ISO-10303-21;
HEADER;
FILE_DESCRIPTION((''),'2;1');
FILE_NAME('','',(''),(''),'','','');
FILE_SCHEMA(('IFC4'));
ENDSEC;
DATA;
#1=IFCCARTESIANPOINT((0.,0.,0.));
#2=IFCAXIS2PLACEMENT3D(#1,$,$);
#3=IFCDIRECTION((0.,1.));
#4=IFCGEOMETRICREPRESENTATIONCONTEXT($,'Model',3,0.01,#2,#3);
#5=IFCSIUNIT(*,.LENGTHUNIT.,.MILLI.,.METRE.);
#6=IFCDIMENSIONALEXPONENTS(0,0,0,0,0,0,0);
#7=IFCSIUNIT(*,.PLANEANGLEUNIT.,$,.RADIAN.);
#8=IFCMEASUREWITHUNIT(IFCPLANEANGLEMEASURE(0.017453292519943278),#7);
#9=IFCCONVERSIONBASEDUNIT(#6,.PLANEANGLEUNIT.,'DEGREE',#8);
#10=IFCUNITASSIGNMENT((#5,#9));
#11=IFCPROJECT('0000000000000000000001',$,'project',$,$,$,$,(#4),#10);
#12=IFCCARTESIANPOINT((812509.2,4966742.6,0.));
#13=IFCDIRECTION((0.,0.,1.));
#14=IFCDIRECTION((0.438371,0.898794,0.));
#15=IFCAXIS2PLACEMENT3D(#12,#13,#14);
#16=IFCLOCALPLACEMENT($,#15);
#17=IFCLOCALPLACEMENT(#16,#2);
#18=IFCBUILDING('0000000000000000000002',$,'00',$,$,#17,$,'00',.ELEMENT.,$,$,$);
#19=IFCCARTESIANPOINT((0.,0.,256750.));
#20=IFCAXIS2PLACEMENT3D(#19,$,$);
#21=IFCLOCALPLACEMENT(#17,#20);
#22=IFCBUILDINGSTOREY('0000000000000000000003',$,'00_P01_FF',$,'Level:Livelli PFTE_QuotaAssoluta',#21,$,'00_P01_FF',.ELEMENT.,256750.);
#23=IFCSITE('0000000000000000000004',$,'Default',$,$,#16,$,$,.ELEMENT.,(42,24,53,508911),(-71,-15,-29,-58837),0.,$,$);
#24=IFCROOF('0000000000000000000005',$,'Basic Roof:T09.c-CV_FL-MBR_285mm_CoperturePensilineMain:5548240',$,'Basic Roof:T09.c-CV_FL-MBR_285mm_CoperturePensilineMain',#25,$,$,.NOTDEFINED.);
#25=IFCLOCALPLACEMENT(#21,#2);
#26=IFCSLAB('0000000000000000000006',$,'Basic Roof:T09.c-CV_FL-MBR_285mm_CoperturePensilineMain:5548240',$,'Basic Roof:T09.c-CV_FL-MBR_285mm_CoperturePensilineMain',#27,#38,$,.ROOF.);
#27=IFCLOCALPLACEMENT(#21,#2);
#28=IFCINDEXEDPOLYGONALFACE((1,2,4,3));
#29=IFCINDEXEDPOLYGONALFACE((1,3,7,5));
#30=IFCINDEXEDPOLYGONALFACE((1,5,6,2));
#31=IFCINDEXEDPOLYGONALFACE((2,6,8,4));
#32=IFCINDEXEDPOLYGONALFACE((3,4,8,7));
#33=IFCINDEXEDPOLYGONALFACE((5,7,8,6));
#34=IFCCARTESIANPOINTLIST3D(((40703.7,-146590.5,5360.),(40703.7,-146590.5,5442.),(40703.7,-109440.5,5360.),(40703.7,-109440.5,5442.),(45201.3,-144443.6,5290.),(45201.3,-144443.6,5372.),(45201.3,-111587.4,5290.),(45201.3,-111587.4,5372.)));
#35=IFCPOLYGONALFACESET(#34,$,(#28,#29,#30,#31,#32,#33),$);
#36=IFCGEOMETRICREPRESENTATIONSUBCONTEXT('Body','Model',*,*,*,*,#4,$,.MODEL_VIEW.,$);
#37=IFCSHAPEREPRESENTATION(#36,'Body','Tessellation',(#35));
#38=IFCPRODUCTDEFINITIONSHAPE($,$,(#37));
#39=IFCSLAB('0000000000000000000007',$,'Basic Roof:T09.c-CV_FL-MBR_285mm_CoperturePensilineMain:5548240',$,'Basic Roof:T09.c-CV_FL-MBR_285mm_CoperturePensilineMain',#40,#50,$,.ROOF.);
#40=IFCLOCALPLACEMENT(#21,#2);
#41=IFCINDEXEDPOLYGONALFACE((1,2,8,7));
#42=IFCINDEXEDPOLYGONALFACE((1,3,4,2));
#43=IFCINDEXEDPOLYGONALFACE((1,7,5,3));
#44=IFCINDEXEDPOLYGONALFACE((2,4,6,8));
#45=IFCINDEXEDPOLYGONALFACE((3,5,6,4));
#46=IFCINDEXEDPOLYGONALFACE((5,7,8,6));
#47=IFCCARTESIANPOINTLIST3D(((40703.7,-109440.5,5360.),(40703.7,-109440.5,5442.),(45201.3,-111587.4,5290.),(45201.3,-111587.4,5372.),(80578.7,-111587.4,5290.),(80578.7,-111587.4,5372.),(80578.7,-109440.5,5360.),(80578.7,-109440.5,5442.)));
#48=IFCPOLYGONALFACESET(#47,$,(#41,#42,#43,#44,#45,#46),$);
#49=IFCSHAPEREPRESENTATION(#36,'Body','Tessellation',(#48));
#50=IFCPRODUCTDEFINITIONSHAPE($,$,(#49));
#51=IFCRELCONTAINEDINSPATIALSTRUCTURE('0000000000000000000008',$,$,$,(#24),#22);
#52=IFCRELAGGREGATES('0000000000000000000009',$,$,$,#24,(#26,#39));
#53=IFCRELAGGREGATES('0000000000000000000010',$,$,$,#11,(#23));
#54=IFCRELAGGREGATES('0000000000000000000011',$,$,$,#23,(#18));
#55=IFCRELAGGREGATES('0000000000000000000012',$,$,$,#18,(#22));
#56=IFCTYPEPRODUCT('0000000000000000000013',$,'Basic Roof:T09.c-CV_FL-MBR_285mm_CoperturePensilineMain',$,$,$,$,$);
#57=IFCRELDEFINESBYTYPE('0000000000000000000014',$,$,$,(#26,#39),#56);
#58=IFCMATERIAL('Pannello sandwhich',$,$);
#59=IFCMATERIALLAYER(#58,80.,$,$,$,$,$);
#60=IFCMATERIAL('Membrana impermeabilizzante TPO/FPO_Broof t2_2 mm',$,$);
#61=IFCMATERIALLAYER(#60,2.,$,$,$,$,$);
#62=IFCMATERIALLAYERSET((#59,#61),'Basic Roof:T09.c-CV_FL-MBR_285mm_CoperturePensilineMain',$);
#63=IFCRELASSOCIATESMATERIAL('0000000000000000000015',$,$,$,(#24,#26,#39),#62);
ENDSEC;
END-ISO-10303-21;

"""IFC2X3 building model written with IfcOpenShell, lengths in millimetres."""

from ifc_helpers import new_model, entity, si_unit, converted_unit, direction, frame, origin, place, context, subcontext, project, spatial, polyline, outline, extrude, material, layer, layer_set, type_object, element, aggregate, save


model = new_model("IFC2X3")

# Units and contexts
model_context = context("Model", 3, precision=0.01, world=origin(), true_north=direction((0.0, 1.0)))
body_context = subcontext(model_context, "Body", "Model", "MODEL_VIEW")
ifc_project = project(units=[si_unit("LENGTHUNIT", "METRE", prefix="MILLI"), converted_unit("PLANEANGLEUNIT", "DEGREE", entity("IfcPlaneAngleMeasure", 0.017453292519943278), si_unit("PLANEANGLEUNIT", "RADIAN"), dimensions=[0, 0, 0, 0, 0, 0, 0])], contexts=[model_context])

# Site, building, storey
site_placement = place(None, frame((812509.2, 4966742.6, 0.0), z_axis=(0.0, 0.0, 1.0), x_axis=(0.438371, 0.898794, 0.0)))
site = spatial("IfcSite", under=ifc_project, at=site_placement, Name="Default", CompositionType="ELEMENT", RefLatitude=(42, 24, 53, 508911), RefLongitude=(-71, -15, -29, -58837), RefElevation=0.0)
building_placement = place(site_placement, origin())
building = spatial("IfcBuilding", under=site, at=building_placement, Name="00", LongName="00", CompositionType="ELEMENT")
storey_placement = place(building_placement, frame((0.0, 0.0, 256750.0)))
storey = spatial("IfcBuildingStorey", under=building, at=storey_placement, Name="00_P01_FF", ObjectType="Level:Livelli PFTE_QuotaAssoluta", LongName="00_P01_FF", CompositionType="ELEMENT", Elevation=256750.0)

# Roof, slabs
ifc_material_1 = material(Name="Pannello sandwhich")
ifc_layer_1 = layer(ifc_material_1, 80.0)
ifc_material_2 = material(Name="Membrana impermeabilizzante TPO/FPO_Broof t2_2 mm")
ifc_layer_2 = layer(ifc_material_2, 2.0)
ifc_layer_set = layer_set([ifc_layer_1, ifc_layer_2], Name="Basic Roof:T09.c-CV_FL-MBR_285mm_CoperturePensilineMain")
roof_placement = place(storey_placement, frame((40703.7, -146590.5, 5290.0)))
roof = element("IfcRoof", 1, at=roof_placement, inside=storey, material=ifc_layer_set, Name="Basic Roof:T09.c-CV_FL-MBR_285mm_CoperturePensilineMain:5548240", ObjectType="Basic Roof:T09.c-CV_FL-MBR_285mm_CoperturePensilineMain", ShapeType="NOTDEFINED")
type_product = type_object("IfcTypeProduct", Name="Basic Roof:T09.c-CV_FL-MBR_285mm_CoperturePensilineMain")
slab_1_placement = place(roof_placement, origin())
slab_1 = element("IfcSlab", 2, at=slab_1_placement, type_object=type_product, material=ifc_layer_set, Name="Basic Roof:T09.c-CV_FL-MBR_285mm_CoperturePensilineMain:5548240", ObjectType="Basic Roof:T09.c-CV_FL-MBR_285mm_CoperturePensilineMain", PredefinedType="ROOF", context=body_context, shape_type="SweptSolid", body=[
    extrude(outline(polyline([(2249.1, -16428.1), (2249.1, 16428.1), (-2249.1, 18575.0), (-2249.1, -18575.0), (2249.1, -16428.1)])), frame((2248.8, 18575.0, 35.0), z_axis=(0.015562, 0.0, 0.999879), x_axis=(0.999879, 0.0, -0.015562)), (-0.015562, 0.0, 0.999879), 82.0),
])
slab_2_placement = place(roof_placement, origin())
slab_2 = element("IfcSlab", 3, at=slab_2_placement, type_object=type_product, material=ifc_layer_set, Name="Basic Roof:T09.c-CV_FL-MBR_285mm_CoperturePensilineMain:5548240", ObjectType="Basic Roof:T09.c-CV_FL-MBR_285mm_CoperturePensilineMain", PredefinedType="ROOF", context=body_context, shape_type="SweptSolid", body=[
    extrude(outline(polyline([(-15439.9, -1074.0), (19937.5, -1074.0), (19937.5, 1074.0), (-19937.5, 1074.0), (-15439.9, -1074.0)])), frame((19937.5, 36076.5, 35.0), z_axis=(0.0, -0.032588, 0.999469), x_axis=(1.0, 0.0, 0.0)), (0.0, 0.032588, 0.999469), 82.0),
])
aggregate(roof, [slab_1, slab_2])

save(model, "model.ifc")
